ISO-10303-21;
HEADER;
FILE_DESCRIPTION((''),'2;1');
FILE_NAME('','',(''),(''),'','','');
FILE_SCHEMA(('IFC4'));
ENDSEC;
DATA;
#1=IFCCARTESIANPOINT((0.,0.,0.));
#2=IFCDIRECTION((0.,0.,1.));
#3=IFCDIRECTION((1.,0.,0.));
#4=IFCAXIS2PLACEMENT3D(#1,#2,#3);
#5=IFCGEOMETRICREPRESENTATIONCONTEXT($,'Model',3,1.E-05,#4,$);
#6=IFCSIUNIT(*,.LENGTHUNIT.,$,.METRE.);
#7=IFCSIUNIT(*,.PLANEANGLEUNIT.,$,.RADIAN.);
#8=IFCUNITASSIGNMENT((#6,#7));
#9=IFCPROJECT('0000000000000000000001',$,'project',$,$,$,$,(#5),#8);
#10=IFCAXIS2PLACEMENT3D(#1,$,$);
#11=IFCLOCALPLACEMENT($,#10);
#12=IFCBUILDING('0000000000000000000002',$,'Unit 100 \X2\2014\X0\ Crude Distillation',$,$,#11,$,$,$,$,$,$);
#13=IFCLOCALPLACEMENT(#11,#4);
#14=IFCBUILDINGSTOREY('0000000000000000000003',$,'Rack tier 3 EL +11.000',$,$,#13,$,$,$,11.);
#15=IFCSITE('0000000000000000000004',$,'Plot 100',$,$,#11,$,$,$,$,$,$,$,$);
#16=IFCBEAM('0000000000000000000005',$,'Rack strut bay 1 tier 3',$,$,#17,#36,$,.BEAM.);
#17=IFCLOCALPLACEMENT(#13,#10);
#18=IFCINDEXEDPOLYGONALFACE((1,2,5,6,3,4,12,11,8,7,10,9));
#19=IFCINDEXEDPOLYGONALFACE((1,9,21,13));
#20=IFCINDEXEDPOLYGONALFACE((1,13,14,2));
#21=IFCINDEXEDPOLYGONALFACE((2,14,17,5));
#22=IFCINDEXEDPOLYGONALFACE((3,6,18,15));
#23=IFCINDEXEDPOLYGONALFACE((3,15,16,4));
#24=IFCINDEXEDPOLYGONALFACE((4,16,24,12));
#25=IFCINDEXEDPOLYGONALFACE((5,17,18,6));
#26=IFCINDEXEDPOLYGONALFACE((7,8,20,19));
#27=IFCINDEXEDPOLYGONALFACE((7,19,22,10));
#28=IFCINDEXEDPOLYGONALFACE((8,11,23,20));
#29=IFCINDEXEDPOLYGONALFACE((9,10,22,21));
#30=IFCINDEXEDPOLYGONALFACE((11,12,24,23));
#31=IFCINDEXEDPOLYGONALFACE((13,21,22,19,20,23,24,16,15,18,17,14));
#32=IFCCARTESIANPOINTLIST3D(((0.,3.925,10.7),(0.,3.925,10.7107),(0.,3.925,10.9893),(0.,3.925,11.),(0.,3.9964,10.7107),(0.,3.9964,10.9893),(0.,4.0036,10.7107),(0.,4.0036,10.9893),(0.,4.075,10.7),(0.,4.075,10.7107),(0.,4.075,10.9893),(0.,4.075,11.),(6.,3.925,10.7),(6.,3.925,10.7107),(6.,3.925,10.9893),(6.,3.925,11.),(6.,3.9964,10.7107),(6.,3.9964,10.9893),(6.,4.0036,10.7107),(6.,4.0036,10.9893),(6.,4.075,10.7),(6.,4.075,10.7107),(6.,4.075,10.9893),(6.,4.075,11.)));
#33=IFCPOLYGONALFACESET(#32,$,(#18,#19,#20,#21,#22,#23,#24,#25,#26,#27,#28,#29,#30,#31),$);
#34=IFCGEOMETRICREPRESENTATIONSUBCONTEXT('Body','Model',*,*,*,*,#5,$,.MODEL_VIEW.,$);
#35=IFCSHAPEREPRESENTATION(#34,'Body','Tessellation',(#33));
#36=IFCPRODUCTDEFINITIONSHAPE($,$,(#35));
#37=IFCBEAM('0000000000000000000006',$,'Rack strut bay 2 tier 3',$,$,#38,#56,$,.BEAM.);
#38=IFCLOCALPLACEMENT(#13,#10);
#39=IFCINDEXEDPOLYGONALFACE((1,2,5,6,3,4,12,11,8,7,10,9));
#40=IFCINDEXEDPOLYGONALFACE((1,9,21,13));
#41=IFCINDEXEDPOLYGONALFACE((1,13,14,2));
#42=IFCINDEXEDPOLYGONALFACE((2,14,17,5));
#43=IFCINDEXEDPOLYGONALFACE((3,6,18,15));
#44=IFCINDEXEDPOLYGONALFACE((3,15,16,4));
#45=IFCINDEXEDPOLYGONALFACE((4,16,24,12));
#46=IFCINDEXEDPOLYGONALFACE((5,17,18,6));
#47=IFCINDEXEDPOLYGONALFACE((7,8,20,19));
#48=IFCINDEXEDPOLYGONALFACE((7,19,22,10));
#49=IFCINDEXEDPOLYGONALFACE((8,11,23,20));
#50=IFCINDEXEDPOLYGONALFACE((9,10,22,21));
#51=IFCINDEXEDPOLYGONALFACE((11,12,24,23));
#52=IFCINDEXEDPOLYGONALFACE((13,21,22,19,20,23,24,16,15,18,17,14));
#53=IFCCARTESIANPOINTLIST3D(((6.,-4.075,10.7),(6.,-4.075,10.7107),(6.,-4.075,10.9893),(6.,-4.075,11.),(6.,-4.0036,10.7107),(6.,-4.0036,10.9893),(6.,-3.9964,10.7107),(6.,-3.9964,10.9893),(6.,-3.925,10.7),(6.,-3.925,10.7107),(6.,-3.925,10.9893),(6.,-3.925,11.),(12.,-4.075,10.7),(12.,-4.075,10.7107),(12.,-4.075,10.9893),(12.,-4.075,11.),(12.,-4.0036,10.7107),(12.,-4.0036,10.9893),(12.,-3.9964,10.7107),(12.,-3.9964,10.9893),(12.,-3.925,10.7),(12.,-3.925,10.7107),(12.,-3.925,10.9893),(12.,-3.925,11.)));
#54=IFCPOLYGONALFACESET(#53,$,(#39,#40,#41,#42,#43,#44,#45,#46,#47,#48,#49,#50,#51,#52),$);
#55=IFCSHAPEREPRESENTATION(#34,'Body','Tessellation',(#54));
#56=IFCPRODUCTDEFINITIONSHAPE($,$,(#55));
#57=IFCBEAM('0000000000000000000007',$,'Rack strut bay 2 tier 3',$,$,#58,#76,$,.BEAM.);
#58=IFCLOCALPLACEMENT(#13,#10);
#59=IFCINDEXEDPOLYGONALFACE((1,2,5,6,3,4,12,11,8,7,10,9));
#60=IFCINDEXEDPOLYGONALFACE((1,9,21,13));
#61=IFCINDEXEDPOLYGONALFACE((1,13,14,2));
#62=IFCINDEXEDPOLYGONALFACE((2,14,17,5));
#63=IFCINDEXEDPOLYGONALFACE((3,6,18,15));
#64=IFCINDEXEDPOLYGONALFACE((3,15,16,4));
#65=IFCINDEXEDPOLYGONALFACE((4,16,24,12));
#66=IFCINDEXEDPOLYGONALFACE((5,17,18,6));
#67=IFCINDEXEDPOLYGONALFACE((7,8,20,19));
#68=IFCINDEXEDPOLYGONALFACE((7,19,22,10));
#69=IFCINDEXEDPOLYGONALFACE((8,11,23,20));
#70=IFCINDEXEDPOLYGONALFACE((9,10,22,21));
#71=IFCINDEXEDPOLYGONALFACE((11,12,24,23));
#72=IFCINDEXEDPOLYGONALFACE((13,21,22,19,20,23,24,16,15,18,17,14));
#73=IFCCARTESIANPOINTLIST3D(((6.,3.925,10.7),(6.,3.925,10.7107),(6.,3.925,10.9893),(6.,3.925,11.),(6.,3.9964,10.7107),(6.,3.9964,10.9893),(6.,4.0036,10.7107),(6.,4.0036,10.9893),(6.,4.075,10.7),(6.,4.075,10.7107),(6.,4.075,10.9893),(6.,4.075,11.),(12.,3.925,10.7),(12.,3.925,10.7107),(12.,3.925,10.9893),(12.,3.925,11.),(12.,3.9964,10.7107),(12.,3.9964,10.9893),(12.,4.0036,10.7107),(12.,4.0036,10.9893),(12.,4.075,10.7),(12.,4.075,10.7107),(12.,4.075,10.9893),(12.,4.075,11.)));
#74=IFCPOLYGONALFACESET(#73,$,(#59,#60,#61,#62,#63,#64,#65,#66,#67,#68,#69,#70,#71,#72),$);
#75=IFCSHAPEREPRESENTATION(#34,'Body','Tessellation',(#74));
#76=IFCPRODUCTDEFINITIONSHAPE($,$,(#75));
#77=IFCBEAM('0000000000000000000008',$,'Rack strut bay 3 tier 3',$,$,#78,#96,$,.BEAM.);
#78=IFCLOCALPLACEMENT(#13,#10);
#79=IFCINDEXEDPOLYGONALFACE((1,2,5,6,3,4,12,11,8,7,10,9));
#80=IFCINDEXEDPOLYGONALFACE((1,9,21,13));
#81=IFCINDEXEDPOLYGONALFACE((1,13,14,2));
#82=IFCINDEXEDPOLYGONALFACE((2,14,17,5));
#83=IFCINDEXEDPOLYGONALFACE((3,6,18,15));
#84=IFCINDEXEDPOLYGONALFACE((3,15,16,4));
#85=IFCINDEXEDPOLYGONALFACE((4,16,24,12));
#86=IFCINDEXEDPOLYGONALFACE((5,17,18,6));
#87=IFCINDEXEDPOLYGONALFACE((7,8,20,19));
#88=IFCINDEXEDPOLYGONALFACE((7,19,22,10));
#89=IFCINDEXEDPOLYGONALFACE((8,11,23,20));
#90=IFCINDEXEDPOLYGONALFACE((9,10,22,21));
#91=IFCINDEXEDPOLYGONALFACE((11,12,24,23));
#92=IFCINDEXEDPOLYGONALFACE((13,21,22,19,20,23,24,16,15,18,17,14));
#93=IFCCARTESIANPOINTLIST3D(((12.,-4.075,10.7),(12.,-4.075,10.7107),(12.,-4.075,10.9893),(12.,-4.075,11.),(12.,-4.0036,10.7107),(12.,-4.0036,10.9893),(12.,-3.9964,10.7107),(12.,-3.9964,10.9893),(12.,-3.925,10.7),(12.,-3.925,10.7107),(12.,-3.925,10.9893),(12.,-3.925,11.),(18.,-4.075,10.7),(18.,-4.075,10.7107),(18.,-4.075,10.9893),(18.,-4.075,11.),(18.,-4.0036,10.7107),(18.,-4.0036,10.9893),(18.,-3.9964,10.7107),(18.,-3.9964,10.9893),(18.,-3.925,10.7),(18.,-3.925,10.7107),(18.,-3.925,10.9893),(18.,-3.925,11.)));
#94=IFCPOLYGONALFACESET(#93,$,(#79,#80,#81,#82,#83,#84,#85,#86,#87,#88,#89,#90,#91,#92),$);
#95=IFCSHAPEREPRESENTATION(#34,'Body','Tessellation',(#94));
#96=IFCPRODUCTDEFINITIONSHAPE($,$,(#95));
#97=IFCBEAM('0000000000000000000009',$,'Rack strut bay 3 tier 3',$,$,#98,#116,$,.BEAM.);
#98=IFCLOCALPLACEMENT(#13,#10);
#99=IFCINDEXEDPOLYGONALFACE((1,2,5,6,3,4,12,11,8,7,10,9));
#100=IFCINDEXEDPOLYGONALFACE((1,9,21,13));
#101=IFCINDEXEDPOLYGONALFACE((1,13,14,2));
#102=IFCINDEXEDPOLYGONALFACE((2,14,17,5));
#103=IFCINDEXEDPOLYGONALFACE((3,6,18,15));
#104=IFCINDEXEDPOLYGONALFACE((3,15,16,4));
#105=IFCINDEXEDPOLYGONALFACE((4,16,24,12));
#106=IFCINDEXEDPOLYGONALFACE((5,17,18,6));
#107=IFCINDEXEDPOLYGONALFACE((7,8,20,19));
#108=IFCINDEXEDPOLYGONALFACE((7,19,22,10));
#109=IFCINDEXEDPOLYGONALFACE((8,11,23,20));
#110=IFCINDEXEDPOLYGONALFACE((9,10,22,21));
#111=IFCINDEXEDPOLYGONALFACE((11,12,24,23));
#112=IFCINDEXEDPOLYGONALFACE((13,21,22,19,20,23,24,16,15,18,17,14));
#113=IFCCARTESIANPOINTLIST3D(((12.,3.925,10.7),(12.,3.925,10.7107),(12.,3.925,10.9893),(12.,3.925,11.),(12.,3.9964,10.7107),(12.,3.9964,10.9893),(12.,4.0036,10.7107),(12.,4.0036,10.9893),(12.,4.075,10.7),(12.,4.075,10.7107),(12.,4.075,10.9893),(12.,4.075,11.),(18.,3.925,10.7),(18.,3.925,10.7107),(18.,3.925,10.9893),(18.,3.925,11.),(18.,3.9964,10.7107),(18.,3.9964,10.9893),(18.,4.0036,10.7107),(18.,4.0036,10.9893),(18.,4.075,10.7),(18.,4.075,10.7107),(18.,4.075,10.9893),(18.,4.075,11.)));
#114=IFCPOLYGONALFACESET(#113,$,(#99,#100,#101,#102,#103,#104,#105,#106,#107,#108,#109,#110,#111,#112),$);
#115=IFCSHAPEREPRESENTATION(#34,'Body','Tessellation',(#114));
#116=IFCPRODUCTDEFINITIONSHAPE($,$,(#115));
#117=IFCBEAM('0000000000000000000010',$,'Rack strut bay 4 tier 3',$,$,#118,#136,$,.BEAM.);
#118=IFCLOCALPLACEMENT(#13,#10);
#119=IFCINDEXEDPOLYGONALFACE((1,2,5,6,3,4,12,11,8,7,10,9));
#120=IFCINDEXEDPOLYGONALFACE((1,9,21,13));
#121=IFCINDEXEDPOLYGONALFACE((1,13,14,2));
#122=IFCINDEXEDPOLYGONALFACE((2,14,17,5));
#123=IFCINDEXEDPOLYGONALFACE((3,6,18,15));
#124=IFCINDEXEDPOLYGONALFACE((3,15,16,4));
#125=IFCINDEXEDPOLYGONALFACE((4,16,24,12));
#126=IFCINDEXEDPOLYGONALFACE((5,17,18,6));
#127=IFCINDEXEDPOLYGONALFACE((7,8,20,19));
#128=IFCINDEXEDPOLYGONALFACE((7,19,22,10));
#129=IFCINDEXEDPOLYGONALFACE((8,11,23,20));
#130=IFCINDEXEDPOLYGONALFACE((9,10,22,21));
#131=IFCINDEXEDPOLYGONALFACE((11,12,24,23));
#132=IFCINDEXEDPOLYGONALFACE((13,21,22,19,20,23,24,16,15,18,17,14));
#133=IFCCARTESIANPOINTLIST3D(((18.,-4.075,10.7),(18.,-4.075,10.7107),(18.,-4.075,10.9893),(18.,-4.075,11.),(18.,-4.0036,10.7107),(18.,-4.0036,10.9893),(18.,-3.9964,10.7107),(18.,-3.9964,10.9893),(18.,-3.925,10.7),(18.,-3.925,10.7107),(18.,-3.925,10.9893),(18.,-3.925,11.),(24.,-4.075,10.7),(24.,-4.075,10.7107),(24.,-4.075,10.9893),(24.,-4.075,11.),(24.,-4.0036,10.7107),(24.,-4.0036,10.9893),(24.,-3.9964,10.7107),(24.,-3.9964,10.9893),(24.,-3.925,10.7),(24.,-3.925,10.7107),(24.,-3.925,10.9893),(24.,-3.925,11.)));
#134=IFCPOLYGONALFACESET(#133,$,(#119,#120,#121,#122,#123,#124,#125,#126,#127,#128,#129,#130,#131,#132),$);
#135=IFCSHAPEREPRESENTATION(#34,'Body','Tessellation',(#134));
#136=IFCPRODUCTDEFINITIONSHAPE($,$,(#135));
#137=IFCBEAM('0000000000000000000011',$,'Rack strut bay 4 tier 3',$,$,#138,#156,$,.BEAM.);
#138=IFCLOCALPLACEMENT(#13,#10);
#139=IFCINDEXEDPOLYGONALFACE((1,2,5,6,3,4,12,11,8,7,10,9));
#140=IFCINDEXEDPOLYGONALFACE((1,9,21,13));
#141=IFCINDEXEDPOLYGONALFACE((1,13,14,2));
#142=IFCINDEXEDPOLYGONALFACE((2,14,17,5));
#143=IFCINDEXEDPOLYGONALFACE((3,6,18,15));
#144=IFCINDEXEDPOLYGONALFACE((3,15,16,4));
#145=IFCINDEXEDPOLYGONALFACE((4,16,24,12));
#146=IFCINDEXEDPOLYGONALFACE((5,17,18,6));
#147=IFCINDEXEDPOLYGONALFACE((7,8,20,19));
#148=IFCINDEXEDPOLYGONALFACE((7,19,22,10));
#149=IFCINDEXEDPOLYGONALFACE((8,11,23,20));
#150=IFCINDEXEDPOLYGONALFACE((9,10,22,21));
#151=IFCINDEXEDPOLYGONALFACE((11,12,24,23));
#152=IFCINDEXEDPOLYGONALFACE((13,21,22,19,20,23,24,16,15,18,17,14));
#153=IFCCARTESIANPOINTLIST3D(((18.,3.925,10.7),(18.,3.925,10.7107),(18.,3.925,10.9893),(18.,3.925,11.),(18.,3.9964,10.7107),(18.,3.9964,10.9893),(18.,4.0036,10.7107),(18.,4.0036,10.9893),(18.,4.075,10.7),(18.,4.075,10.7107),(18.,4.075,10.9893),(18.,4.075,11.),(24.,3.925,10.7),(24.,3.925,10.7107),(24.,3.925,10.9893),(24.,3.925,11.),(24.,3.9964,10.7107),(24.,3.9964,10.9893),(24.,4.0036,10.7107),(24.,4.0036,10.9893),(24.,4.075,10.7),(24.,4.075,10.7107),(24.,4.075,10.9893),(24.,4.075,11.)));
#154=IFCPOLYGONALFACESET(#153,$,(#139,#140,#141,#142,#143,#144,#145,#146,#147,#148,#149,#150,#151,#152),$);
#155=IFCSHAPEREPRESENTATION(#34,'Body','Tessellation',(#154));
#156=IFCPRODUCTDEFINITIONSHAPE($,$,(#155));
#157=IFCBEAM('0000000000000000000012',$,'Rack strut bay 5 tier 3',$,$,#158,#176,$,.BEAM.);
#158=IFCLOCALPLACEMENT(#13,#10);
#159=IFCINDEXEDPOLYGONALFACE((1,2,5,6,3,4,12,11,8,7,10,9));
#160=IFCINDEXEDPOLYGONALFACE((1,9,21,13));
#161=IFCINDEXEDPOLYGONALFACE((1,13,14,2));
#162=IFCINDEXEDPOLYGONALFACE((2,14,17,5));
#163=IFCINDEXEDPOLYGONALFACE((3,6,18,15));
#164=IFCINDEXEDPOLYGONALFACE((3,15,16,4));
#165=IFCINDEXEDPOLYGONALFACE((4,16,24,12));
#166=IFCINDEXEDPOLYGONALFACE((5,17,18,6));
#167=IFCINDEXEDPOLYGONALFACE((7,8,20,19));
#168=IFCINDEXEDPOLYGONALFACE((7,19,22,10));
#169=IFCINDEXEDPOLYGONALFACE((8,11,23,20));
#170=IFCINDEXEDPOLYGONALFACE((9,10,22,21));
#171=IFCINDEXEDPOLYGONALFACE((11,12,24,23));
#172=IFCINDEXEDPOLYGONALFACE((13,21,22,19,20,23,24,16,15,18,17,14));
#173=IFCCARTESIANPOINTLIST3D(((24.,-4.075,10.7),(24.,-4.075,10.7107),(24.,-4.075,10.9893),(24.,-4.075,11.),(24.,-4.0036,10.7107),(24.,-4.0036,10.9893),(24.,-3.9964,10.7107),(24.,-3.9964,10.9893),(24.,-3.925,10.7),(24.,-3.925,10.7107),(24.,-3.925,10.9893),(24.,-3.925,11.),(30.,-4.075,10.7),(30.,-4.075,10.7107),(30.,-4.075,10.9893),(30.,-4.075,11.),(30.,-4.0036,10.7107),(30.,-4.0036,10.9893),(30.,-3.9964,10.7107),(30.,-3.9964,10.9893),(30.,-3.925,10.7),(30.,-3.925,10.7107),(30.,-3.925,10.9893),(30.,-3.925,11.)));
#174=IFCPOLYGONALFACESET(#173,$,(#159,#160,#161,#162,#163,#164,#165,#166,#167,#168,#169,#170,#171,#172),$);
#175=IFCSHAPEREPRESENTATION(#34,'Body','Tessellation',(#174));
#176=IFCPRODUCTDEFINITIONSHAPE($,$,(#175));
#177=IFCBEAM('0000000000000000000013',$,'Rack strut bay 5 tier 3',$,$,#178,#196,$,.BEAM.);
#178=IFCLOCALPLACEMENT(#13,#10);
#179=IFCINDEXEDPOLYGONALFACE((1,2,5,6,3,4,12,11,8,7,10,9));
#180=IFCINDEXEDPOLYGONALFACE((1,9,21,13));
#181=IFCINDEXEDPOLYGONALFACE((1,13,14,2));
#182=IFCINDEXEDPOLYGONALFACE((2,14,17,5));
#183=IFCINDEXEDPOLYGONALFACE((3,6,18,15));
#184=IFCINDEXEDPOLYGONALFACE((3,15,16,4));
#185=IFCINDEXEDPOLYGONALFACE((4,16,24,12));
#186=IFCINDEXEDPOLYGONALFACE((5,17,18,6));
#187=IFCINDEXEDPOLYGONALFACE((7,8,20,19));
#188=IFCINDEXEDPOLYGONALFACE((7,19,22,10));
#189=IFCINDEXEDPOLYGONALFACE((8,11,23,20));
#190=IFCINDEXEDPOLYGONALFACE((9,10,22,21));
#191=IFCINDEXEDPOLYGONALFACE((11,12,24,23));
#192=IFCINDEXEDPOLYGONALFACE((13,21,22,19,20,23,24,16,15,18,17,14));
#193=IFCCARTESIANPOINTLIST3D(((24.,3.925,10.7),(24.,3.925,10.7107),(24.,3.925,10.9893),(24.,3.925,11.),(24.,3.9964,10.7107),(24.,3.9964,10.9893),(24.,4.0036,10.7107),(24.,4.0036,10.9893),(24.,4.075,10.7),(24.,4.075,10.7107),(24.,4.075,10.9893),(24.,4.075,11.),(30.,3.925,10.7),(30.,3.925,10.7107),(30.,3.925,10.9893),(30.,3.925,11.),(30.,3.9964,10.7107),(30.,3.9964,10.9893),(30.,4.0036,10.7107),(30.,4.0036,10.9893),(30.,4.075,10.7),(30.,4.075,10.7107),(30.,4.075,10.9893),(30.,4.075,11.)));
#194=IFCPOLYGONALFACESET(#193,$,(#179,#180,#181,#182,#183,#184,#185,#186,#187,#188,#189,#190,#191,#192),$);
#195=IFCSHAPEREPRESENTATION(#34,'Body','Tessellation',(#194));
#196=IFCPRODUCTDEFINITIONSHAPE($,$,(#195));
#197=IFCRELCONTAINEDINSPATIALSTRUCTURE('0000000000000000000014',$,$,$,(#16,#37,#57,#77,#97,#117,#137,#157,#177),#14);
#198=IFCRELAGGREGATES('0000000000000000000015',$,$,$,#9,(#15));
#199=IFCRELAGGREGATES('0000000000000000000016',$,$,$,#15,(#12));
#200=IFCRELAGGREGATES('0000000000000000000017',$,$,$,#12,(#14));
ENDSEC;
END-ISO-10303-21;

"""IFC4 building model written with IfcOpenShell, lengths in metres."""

from ifc_helpers import new_model, si_unit, frame, origin, origin_with_axes, origin_2d, place, context, subcontext, project, spatial, i_section, extrude, element, save


model = new_model("IFC4")

# Units and contexts
model_context = context("Model", 3, precision=1e-05, world=origin_with_axes())
body_context = subcontext(model_context, "Body", "Model", "MODEL_VIEW")
ifc_project = project(units=[si_unit("LENGTHUNIT", "METRE"), si_unit("PLANEANGLEUNIT", "RADIAN")], contexts=[model_context])

# Site, building, storey
placement = place(None, origin())
site = spatial("IfcSite", under=ifc_project, at=placement, Name="Plot 100")
building = spatial("IfcBuilding", under=site, at=placement, Name="Unit 100 — Crude Distillation")
storey_placement = place(placement, origin_with_axes())
storey = spatial("IfcBuildingStorey", under=building, at=storey_placement, Name="Rack tier 3 EL +11.000", Elevation=11.0)

# Beams
beam_1_placement = place(storey_placement, origin_with_axes())
element("IfcBeam", 1, at=beam_1_placement, inside=storey, Name="Rack strut bay 1 tier 3", PredefinedType="BEAM", context=body_context, shape_type="SweptSolid", body=[
    extrude(i_section(OverallWidth=0.15, OverallDepth=0.3, WebThickness=0.0071, FlangeThickness=0.0107, at=origin_2d()), frame((0.0, 4.0, 10.85), z_axis=(1.0, 0.0, 0.0), x_axis=(0.0, 1.0, 0.0)), (0.0, 0.0, 1.0), 6.0),
])
beam_2_placement = place(storey_placement, origin_with_axes())
element("IfcBeam", 2, at=beam_2_placement, inside=storey, Name="Rack strut bay 2 tier 3", PredefinedType="BEAM", context=body_context, shape_type="SweptSolid", body=[
    extrude(i_section(OverallWidth=0.15, OverallDepth=0.3, WebThickness=0.0071, FlangeThickness=0.0107, at=origin_2d()), frame((6.0, -4.0, 10.85), z_axis=(1.0, 0.0, 0.0), x_axis=(0.0, 1.0, 0.0)), (0.0, 0.0, 1.0), 6.0),
])
beam_3_placement = place(storey_placement, origin_with_axes())
element("IfcBeam", 3, at=beam_3_placement, inside=storey, Name="Rack strut bay 2 tier 3", PredefinedType="BEAM", context=body_context, shape_type="SweptSolid", body=[
    extrude(i_section(OverallWidth=0.15, OverallDepth=0.3, WebThickness=0.0071, FlangeThickness=0.0107, at=origin_2d()), frame((6.0, 4.0, 10.85), z_axis=(1.0, 0.0, 0.0), x_axis=(0.0, 1.0, 0.0)), (0.0, 0.0, 1.0), 6.0),
])
beam_4_placement = place(storey_placement, origin_with_axes())
element("IfcBeam", 4, at=beam_4_placement, inside=storey, Name="Rack strut bay 3 tier 3", PredefinedType="BEAM", context=body_context, shape_type="SweptSolid", body=[
    extrude(i_section(OverallWidth=0.15, OverallDepth=0.3, WebThickness=0.0071, FlangeThickness=0.0107, at=origin_2d()), frame((12.0, -4.0, 10.85), z_axis=(1.0, 0.0, 0.0), x_axis=(0.0, 1.0, 0.0)), (0.0, 0.0, 1.0), 6.0),
])
beam_5_placement = place(storey_placement, origin_with_axes())
element("IfcBeam", 5, at=beam_5_placement, inside=storey, Name="Rack strut bay 3 tier 3", PredefinedType="BEAM", context=body_context, shape_type="SweptSolid", body=[
    extrude(i_section(OverallWidth=0.15, OverallDepth=0.3, WebThickness=0.0071, FlangeThickness=0.0107, at=origin_2d()), frame((12.0, 4.0, 10.85), z_axis=(1.0, 0.0, 0.0), x_axis=(0.0, 1.0, 0.0)), (0.0, 0.0, 1.0), 6.0),
])
beam_6_placement = place(storey_placement, origin_with_axes())
element("IfcBeam", 6, at=beam_6_placement, inside=storey, Name="Rack strut bay 4 tier 3", PredefinedType="BEAM", context=body_context, shape_type="SweptSolid", body=[
    extrude(i_section(OverallWidth=0.15, OverallDepth=0.3, WebThickness=0.0071, FlangeThickness=0.0107, at=origin_2d()), frame((18.0, -4.0, 10.85), z_axis=(1.0, 0.0, 0.0), x_axis=(0.0, 1.0, 0.0)), (0.0, 0.0, 1.0), 6.0),
])
beam_7_placement = place(storey_placement, origin_with_axes())
element("IfcBeam", 7, at=beam_7_placement, inside=storey, Name="Rack strut bay 4 tier 3", PredefinedType="BEAM", context=body_context, shape_type="SweptSolid", body=[
    extrude(i_section(OverallWidth=0.15, OverallDepth=0.3, WebThickness=0.0071, FlangeThickness=0.0107, at=origin_2d()), frame((18.0, 4.0, 10.85), z_axis=(1.0, 0.0, 0.0), x_axis=(0.0, 1.0, 0.0)), (0.0, 0.0, 1.0), 6.0),
])
beam_8_placement = place(storey_placement, origin_with_axes())
element("IfcBeam", 8, at=beam_8_placement, inside=storey, Name="Rack strut bay 5 tier 3", PredefinedType="BEAM", context=body_context, shape_type="SweptSolid", body=[
    extrude(i_section(OverallWidth=0.15, OverallDepth=0.3, WebThickness=0.0071, FlangeThickness=0.0107, at=origin_2d()), frame((24.0, -4.0, 10.85), z_axis=(1.0, 0.0, 0.0), x_axis=(0.0, 1.0, 0.0)), (0.0, 0.0, 1.0), 6.0),
])
beam_9_placement = place(storey_placement, origin_with_axes())
element("IfcBeam", 9, at=beam_9_placement, inside=storey, Name="Rack strut bay 5 tier 3", PredefinedType="BEAM", context=body_context, shape_type="SweptSolid", body=[
    extrude(i_section(OverallWidth=0.15, OverallDepth=0.3, WebThickness=0.0071, FlangeThickness=0.0107, at=origin_2d()), frame((24.0, 4.0, 10.85), z_axis=(1.0, 0.0, 0.0), x_axis=(0.0, 1.0, 0.0)), (0.0, 0.0, 1.0), 6.0),
])

save(model, "model.ifc")
